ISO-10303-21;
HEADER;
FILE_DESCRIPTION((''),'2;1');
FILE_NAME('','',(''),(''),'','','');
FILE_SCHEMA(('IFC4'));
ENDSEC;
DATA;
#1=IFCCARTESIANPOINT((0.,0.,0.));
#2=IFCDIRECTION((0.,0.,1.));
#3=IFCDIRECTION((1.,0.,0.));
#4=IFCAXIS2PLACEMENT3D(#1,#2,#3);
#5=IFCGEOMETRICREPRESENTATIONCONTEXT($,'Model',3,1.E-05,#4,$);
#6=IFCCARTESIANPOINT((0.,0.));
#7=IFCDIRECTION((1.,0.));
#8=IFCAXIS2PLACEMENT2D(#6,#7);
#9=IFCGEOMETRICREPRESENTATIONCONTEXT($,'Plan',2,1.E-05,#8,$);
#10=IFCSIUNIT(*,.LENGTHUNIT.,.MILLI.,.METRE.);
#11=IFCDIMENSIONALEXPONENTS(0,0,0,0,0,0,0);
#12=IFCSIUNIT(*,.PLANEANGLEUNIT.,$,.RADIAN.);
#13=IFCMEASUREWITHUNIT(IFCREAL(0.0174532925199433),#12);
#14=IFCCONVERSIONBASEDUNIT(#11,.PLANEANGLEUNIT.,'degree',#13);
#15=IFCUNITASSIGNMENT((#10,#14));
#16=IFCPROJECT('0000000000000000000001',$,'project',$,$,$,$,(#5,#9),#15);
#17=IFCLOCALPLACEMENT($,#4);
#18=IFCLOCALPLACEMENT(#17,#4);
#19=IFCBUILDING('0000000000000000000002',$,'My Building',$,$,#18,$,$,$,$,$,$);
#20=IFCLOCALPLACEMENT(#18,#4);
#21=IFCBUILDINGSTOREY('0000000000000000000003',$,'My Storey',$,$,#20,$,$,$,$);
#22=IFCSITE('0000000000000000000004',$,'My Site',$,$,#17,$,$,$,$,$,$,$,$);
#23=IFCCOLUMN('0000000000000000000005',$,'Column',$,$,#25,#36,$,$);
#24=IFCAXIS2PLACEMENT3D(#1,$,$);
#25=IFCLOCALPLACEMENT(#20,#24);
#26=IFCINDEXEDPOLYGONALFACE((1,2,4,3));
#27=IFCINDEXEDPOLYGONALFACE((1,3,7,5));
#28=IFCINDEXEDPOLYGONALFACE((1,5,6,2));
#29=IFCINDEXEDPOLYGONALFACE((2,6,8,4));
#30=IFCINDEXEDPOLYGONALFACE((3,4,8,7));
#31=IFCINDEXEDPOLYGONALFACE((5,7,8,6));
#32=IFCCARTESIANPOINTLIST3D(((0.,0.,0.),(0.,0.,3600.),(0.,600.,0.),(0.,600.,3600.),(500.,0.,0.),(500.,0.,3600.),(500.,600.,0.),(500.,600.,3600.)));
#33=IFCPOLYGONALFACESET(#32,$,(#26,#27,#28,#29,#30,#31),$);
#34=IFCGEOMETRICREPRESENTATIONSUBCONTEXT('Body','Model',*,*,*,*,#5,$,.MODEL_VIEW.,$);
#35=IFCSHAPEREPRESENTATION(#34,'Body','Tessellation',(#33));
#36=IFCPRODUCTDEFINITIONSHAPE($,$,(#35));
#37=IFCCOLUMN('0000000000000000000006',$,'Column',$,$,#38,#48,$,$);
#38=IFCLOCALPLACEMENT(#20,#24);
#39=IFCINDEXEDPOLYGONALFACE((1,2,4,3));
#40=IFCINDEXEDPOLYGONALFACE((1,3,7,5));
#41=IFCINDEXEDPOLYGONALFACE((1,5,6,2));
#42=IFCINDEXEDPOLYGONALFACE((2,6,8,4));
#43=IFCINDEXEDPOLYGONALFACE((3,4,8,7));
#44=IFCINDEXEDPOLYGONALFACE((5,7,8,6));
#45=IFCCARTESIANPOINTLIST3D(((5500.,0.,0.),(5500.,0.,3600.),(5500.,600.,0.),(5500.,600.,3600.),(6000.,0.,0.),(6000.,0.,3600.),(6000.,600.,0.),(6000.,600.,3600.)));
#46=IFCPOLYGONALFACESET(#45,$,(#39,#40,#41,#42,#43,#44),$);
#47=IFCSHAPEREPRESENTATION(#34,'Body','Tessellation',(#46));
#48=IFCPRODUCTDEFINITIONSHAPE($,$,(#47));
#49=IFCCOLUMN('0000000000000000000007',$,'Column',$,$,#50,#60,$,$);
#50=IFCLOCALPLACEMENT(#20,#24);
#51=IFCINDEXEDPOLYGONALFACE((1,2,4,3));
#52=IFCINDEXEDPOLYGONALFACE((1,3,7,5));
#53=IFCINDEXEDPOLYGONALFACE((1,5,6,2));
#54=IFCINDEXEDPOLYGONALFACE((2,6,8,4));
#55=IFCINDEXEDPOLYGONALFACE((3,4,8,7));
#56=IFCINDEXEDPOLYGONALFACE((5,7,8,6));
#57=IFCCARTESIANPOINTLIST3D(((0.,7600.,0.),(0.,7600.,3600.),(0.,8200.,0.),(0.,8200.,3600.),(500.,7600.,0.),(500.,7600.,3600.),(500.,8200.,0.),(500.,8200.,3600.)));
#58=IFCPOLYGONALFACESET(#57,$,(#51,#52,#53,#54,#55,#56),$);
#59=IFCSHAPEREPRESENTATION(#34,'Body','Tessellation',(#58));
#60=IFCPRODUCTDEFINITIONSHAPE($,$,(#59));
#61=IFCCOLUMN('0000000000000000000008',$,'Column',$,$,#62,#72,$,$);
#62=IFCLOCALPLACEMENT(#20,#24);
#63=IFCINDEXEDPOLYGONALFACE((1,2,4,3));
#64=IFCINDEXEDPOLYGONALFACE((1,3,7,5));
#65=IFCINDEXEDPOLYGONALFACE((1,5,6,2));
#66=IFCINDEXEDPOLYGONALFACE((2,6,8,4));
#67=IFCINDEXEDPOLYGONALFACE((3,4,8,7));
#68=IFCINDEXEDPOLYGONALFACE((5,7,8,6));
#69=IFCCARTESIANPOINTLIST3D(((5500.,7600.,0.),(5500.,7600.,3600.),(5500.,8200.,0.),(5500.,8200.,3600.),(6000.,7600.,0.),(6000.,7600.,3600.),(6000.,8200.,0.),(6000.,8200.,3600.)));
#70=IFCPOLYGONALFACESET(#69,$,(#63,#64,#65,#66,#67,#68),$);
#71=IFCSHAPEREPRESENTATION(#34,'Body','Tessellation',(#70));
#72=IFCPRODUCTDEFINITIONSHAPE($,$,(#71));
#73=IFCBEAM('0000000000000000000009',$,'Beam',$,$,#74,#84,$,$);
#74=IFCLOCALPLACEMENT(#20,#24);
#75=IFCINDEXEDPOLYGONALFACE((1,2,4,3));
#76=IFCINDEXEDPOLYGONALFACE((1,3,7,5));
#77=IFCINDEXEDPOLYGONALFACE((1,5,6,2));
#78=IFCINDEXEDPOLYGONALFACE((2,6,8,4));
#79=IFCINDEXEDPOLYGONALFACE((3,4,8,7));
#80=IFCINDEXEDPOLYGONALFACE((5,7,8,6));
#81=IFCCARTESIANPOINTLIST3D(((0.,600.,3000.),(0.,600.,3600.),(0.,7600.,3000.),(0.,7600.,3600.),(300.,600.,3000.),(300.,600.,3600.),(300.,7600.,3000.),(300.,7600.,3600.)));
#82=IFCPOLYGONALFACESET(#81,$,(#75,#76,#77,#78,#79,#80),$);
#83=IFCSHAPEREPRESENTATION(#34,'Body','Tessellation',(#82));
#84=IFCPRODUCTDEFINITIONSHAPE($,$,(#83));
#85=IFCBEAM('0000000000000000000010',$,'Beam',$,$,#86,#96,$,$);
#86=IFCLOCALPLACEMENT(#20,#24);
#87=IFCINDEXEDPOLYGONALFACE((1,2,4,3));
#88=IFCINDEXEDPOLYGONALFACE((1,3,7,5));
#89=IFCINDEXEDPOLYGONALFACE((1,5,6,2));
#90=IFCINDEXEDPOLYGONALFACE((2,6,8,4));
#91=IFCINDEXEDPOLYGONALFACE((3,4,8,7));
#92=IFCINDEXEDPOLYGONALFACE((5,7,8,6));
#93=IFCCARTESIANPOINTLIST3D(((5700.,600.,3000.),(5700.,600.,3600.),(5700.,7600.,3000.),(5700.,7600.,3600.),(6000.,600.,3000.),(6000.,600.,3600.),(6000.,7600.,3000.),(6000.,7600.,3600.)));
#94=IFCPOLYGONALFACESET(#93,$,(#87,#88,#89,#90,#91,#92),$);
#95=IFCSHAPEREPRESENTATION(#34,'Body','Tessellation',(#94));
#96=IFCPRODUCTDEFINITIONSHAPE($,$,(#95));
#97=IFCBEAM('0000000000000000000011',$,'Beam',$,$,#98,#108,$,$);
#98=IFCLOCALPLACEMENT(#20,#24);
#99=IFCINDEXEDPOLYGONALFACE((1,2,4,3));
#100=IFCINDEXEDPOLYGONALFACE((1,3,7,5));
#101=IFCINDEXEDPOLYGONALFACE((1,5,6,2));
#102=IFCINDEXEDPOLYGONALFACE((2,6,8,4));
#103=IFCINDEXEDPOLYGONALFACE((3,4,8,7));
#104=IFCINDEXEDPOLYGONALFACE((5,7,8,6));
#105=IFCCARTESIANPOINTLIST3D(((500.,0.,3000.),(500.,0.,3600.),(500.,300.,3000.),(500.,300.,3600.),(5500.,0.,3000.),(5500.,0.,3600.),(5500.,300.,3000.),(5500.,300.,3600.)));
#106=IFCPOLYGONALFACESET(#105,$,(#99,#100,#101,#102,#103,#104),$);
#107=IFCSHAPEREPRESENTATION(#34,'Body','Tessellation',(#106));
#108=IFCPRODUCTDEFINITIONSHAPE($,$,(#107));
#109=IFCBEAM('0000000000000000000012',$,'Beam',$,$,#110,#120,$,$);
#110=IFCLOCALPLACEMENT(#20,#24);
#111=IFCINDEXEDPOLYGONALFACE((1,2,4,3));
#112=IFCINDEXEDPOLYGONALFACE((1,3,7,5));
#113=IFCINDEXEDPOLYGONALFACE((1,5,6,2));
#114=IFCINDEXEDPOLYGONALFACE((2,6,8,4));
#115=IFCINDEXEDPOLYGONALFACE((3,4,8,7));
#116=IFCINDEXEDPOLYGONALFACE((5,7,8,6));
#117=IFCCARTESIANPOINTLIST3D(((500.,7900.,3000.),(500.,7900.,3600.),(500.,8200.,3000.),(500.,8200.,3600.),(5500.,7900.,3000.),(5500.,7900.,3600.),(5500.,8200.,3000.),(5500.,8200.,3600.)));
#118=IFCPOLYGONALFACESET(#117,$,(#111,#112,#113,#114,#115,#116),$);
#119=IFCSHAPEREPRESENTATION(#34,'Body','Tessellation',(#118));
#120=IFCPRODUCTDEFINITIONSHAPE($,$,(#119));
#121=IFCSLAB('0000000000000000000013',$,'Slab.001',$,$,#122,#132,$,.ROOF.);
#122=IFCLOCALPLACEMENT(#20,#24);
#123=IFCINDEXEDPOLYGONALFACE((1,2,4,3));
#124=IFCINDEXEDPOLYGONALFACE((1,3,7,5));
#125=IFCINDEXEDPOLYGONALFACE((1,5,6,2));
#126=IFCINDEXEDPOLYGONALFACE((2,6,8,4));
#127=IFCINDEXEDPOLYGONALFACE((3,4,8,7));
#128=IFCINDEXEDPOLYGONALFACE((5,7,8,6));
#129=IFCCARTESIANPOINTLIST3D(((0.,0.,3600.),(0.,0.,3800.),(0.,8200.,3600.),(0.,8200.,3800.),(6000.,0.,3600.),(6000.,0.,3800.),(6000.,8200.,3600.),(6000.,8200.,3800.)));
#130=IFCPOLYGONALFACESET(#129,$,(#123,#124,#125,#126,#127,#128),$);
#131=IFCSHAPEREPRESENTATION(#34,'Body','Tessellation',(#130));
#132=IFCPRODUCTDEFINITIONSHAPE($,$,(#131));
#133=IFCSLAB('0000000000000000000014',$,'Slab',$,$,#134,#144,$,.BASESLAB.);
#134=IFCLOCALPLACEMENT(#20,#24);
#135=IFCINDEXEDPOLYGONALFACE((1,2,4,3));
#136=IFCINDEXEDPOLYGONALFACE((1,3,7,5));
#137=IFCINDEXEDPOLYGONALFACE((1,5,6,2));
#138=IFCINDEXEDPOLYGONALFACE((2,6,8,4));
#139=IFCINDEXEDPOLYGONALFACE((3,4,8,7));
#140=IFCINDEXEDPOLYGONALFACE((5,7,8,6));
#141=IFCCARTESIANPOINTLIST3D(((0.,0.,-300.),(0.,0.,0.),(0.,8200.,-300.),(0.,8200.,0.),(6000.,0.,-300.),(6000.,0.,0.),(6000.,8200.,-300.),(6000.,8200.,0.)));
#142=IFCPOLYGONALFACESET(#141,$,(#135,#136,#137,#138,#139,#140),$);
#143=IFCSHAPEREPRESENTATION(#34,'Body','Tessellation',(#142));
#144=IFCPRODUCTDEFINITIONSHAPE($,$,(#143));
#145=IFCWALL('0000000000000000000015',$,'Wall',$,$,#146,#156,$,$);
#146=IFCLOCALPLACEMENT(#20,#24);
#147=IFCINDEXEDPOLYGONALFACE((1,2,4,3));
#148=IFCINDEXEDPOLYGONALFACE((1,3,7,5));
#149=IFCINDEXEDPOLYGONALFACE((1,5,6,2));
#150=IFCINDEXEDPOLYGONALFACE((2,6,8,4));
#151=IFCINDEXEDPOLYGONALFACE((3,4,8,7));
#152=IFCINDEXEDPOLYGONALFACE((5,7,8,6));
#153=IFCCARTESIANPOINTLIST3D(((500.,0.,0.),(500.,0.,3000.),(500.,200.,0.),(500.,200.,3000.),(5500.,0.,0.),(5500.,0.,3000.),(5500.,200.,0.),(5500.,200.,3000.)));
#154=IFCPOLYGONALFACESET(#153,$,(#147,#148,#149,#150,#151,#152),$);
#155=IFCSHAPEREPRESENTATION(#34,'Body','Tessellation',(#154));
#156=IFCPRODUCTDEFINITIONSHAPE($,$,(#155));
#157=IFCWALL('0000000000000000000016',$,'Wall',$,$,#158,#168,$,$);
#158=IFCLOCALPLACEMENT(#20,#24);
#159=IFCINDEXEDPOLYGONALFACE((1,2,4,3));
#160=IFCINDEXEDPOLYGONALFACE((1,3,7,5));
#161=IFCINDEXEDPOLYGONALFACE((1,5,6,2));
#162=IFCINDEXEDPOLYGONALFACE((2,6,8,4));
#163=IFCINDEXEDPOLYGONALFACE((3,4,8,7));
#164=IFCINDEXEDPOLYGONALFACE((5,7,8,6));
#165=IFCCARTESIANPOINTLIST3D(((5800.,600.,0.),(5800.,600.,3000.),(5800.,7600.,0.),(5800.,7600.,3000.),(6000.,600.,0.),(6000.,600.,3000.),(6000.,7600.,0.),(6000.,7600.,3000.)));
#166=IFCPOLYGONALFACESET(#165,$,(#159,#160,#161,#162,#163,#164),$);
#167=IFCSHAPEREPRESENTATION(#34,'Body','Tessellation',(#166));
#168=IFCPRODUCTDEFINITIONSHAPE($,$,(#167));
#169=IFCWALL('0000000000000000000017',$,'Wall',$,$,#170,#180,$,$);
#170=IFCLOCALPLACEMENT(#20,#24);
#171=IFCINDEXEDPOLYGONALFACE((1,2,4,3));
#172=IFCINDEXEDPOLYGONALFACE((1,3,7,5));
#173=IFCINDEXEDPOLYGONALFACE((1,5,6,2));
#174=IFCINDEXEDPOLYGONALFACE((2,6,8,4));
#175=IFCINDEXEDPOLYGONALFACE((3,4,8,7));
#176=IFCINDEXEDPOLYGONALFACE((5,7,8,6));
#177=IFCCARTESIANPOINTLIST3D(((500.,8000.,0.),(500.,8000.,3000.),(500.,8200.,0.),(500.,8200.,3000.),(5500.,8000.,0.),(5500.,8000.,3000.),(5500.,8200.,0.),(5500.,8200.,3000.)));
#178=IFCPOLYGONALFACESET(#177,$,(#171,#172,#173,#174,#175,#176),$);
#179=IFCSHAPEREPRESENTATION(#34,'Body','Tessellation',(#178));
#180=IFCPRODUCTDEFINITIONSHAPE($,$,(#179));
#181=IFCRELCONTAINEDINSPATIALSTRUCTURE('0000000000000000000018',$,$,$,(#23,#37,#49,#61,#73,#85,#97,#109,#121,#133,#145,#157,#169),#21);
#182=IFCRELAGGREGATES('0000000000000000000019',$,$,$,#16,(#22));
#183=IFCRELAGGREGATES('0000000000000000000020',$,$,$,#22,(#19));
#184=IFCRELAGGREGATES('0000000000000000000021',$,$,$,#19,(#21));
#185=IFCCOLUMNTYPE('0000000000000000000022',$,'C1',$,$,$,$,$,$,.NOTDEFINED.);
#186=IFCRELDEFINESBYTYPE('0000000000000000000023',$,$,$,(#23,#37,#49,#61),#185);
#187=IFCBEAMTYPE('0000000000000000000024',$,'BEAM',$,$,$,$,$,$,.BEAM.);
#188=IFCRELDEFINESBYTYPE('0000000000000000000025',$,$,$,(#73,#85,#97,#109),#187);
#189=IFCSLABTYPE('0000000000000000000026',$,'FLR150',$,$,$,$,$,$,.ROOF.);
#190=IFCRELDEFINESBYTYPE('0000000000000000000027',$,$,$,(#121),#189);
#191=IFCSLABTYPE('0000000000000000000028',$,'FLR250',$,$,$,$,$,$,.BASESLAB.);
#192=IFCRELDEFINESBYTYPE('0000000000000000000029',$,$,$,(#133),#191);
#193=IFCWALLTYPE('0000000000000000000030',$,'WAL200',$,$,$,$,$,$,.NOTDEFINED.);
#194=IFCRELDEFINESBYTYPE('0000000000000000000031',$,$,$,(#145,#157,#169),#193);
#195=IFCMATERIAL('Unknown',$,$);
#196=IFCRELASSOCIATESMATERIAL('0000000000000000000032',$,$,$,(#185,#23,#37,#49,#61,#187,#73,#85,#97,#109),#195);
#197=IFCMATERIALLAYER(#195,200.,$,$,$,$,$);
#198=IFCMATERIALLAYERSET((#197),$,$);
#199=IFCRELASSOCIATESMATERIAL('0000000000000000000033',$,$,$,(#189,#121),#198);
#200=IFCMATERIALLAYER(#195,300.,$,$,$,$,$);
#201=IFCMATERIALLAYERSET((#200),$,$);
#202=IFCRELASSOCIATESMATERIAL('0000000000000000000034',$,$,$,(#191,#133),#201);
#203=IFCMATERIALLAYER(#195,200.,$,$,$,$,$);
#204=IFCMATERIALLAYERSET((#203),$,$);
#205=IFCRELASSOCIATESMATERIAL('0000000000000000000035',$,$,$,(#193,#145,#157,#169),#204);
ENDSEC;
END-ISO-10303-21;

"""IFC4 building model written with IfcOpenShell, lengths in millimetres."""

from ifc_helpers import new_model, entity, si_unit, converted_unit, frame, origin_with_axes, origin_2d_with_axis, place, context, subcontext, project, spatial, line, indexed_curve, rectangle, outline, extrude, material, layer, layer_set, layer_usage, material_profile, profile_set, profile_usage, type_object, element, save


model = new_model("IFC4")

# Units and contexts
model_context = context("Model", 3, precision=1e-05, world=origin_with_axes())
plan_context = context("Plan", 2, precision=1e-05, world=origin_2d_with_axis())
body_context = subcontext(model_context, "Body", "Model", "MODEL_VIEW")
ifc_project = project(units=[si_unit("LENGTHUNIT", "METRE", prefix="MILLI"), converted_unit("PLANEANGLEUNIT", "degree", entity("IfcReal", 0.0174532925199433), si_unit("PLANEANGLEUNIT", "RADIAN"), dimensions=[0, 0, 0, 0, 0, 0, 0])], contexts=[model_context, plan_context])

# Site, building, storey
site_placement = place(None, origin_with_axes())
site = spatial("IfcSite", under=ifc_project, at=site_placement, Name="My Site")
building_placement = place(site_placement, origin_with_axes())
building = spatial("IfcBuilding", under=site, at=building_placement, Name="My Building")
storey_placement = place(building_placement, origin_with_axes())
storey = spatial("IfcBuildingStorey", under=building, at=storey_placement, Name="My Storey")

# Columns
ifc_material = material(Name="Unknown")
ifc_material_profile_1 = material_profile(ifc_material, rectangle(XDim=500.0, YDim=600.0))
ifc_profile_set_1 = profile_set([ifc_material_profile_1])
ifc_profile_usage_1 = profile_usage(ifc_profile_set_1, cardinal=5)
column_type = type_object("IfcColumnType", Name="C1", PredefinedType="NOTDEFINED", material=ifc_profile_set_1)
column_1_placement = place(storey_placement, frame((250.0, 300.0, 0.0), z_axis=(0.0, 0.0, 1.0), x_axis=(1.0, 0.0, 0.0)))
element("IfcColumn", 1, at=column_1_placement, inside=storey, type_object=column_type, material=ifc_profile_usage_1, Name="Column", context=body_context, shape_type="SweptSolid", body=[
    extrude(rectangle(XDim=500.0, YDim=600.0), origin_with_axes(), (0.0, 0.0, 1.0), 3600.0),
])
ifc_profile_usage_2 = profile_usage(ifc_profile_set_1, cardinal=5)
column_2_placement = place(storey_placement, frame((5750.0, 300.0, 0.0), z_axis=(0.0, 0.0, 1.0), x_axis=(1.0, 0.0, 0.0)))
element("IfcColumn", 2, at=column_2_placement, inside=storey, type_object=column_type, material=ifc_profile_usage_2, Name="Column", context=body_context, shape_type="SweptSolid", body=[
    extrude(rectangle(XDim=500.0, YDim=600.0), origin_with_axes(), (0.0, 0.0, 1.0), 3600.0),
])
ifc_profile_usage_3 = profile_usage(ifc_profile_set_1, cardinal=5)
column_3_placement = place(storey_placement, frame((250.0, 7900.0, 0.0), z_axis=(0.0, 0.0, 1.0), x_axis=(1.0, 0.0, 0.0)))
element("IfcColumn", 3, at=column_3_placement, inside=storey, type_object=column_type, material=ifc_profile_usage_3, Name="Column", context=body_context, shape_type="SweptSolid", body=[
    extrude(rectangle(XDim=500.0, YDim=600.0), origin_with_axes(), (0.0, 0.0, 1.0), 3600.0),
])
ifc_profile_usage_4 = profile_usage(ifc_profile_set_1, cardinal=5)
column_4_placement = place(storey_placement, frame((5750.0, 7900.0, 0.0), z_axis=(0.0, 0.0, 1.0), x_axis=(1.0, 0.0, 0.0)))
element("IfcColumn", 4, at=column_4_placement, inside=storey, type_object=column_type, material=ifc_profile_usage_4, Name="Column", context=body_context, shape_type="SweptSolid", body=[
    extrude(rectangle(XDim=500.0, YDim=600.0), origin_with_axes(), (0.0, 0.0, 1.0), 3600.0),
])

# Beams
ifc_material_profile_2 = material_profile(ifc_material, rectangle(XDim=300.0, YDim=600.0))
ifc_profile_set_2 = profile_set([ifc_material_profile_2])
ifc_profile_usage_5 = profile_usage(ifc_profile_set_2, cardinal=5)
beam_type = type_object("IfcBeamType", Name="BEAM", PredefinedType="BEAM", material=ifc_profile_set_2)
beam_1_placement = place(storey_placement, frame((150.0, 600.0, 3300.0), z_axis=(0.0, 1.0, 0.0), x_axis=(-1.0, 0.0, 0.0)))
element("IfcBeam", 5, at=beam_1_placement, inside=storey, type_object=beam_type, material=ifc_profile_usage_5, Name="Beam", context=body_context, shape_type="SweptSolid", body=[
    extrude(rectangle(XDim=300.0, YDim=600.0), origin_with_axes(), (0.0, 0.0, 1.0), 7000.0),
])
ifc_profile_usage_6 = profile_usage(ifc_profile_set_2, cardinal=5)
beam_2_placement = place(storey_placement, frame((5850.0, 600.0, 3300.0), z_axis=(0.0, 1.0, 0.0), x_axis=(-1.0, 0.0, 0.0)))
element("IfcBeam", 6, at=beam_2_placement, inside=storey, type_object=beam_type, material=ifc_profile_usage_6, Name="Beam", context=body_context, shape_type="SweptSolid", body=[
    extrude(rectangle(XDim=300.0, YDim=600.0), origin_with_axes(), (0.0, 0.0, 1.0), 7000.0),
])
ifc_profile_usage_7 = profile_usage(ifc_profile_set_2, cardinal=5)
beam_3_placement = place(storey_placement, frame((500.0, 150.0, 3300.0), z_axis=(1.0, 0.0, 0.0), x_axis=(0.0, 1.0, 0.0)))
element("IfcBeam", 7, at=beam_3_placement, inside=storey, type_object=beam_type, material=ifc_profile_usage_7, Name="Beam", context=body_context, shape_type="SweptSolid", body=[
    extrude(rectangle(XDim=300.0, YDim=600.0), origin_with_axes(), (0.0, 0.0, 1.0), 5000.0),
])
ifc_profile_usage_8 = profile_usage(ifc_profile_set_2, cardinal=5)
beam_4_placement = place(storey_placement, frame((500.0, 8050.0, 3300.0), z_axis=(1.0, 0.0, 0.0), x_axis=(0.0, 1.0, 0.0)))
element("IfcBeam", 8, at=beam_4_placement, inside=storey, type_object=beam_type, material=ifc_profile_usage_8, Name="Beam", context=body_context, shape_type="SweptSolid", body=[
    extrude(rectangle(XDim=300.0, YDim=600.0), origin_with_axes(), (0.0, 0.0, 1.0), 5000.0),
])

# Slabs
ifc_layer_1 = layer(ifc_material, 200.0)
ifc_layer_set_1 = layer_set([ifc_layer_1])
ifc_layer_usage_1 = layer_usage(ifc_layer_set_1, "AXIS3", "POSITIVE", 0.0)
slab_type_1 = type_object("IfcSlabType", Name="FLR150", PredefinedType="ROOF", material=ifc_layer_set_1)
slab_1_placement = place(storey_placement, frame((0.0, 0.0, 3600.0), z_axis=(0.0, 0.0, 1.0), x_axis=(1.0, 0.0, 0.0)))
element("IfcSlab", 9, at=slab_1_placement, inside=storey, type_object=slab_type_1, material=ifc_layer_usage_1, Name="Slab.001", PredefinedType="ROOF", context=body_context, shape_type="SweptSolid", body=[
    extrude(outline(indexed_curve([(0.0, 0.0), (6000.0, 0.0), (6000.0, 8200.0), (0.0, 8200.0)], segments=[line(3, 2), line(2, 1), line(1, 4), line(4, 3)], self_intersect=False)), None, (0.0, 0.0, 1.0), 200.0),
])
ifc_layer_2 = layer(ifc_material, 300.0)
ifc_layer_set_2 = layer_set([ifc_layer_2])
ifc_layer_usage_2 = layer_usage(ifc_layer_set_2, "AXIS3", "POSITIVE", 0.0)
slab_type_2 = type_object("IfcSlabType", Name="FLR250", PredefinedType="BASESLAB", material=ifc_layer_set_2)
slab_2_placement = place(storey_placement, frame((0.0, 0.0, -300.0), z_axis=(0.0, 0.0, 1.0), x_axis=(1.0, 0.0, 0.0)))
element("IfcSlab", 10, at=slab_2_placement, inside=storey, type_object=slab_type_2, material=ifc_layer_usage_2, Name="Slab", PredefinedType="BASESLAB", context=body_context, shape_type="SweptSolid", body=[
    extrude(outline(indexed_curve([(0.0, 0.0), (6000.0, 0.0), (6000.0, 8200.0), (0.0, 8200.0)], segments=[line(3, 2), line(2, 1), line(1, 4), line(4, 3)], self_intersect=False)), None, (0.0, 0.0, 1.0), 300.0),
])

# Walls
ifc_layer_3 = layer(ifc_material, 200.0)
ifc_layer_set_3 = layer_set([ifc_layer_3])
ifc_layer_usage_3 = layer_usage(ifc_layer_set_3, "AXIS2", "POSITIVE", 0.0)
wall_type = type_object("IfcWallType", Name="WAL200", PredefinedType="NOTDEFINED", material=ifc_layer_set_3)
wall_1_placement = place(storey_placement, frame((500.0, 0.0, 0.0), z_axis=(0.0, 0.0, 1.0), x_axis=(1.0, 0.0, 0.0)))
element("IfcWall", 11, at=wall_1_placement, inside=storey, type_object=wall_type, material=ifc_layer_usage_3, Name="Wall", context=body_context, shape_type="SweptSolid", body=[
    extrude(outline(indexed_curve([(0.0, 0.0), (0.0, 200.0), (5000.0, 200.0), (5000.0, 0.0), (0.0, 0.0)], self_intersect=False)), origin_with_axes(), (0.0, 0.0, 1.0), 3000.0),
])
ifc_layer_usage_4 = layer_usage(ifc_layer_set_3, "AXIS2", "POSITIVE", 0.0)
wall_2_placement = place(storey_placement, frame((6000.0, 600.0, 0.0), z_axis=(0.0, 0.0, 1.0), x_axis=(0.0, 1.0, 0.0)))
element("IfcWall", 12, at=wall_2_placement, inside=storey, type_object=wall_type, material=ifc_layer_usage_4, Name="Wall", context=body_context, shape_type="SweptSolid", body=[
    extrude(outline(indexed_curve([(0.0, 0.0), (0.0, 200.0), (7000.0, 200.0), (7000.0, 0.0), (0.0, 0.0)], self_intersect=False)), origin_with_axes(), (0.0, 0.0, 1.0), 3000.0),
])
ifc_layer_usage_5 = layer_usage(ifc_layer_set_3, "AXIS2", "POSITIVE", 0.0)
wall_3_placement = place(storey_placement, frame((5500.0, 8200.0, 0.0), z_axis=(0.0, 0.0, 1.0), x_axis=(-1.0, 0.0, 0.0)))
element("IfcWall", 13, at=wall_3_placement, inside=storey, type_object=wall_type, material=ifc_layer_usage_5, Name="Wall", context=body_context, shape_type="SweptSolid", body=[
    extrude(outline(indexed_curve([(0.0, 0.0), (0.0, 200.0), (5000.0, 200.0), (5000.0, 0.0), (0.0, 0.0)], self_intersect=False)), origin_with_axes(), (0.0, 0.0, 1.0), 3000.0),
])

save(model, "model.ifc")
